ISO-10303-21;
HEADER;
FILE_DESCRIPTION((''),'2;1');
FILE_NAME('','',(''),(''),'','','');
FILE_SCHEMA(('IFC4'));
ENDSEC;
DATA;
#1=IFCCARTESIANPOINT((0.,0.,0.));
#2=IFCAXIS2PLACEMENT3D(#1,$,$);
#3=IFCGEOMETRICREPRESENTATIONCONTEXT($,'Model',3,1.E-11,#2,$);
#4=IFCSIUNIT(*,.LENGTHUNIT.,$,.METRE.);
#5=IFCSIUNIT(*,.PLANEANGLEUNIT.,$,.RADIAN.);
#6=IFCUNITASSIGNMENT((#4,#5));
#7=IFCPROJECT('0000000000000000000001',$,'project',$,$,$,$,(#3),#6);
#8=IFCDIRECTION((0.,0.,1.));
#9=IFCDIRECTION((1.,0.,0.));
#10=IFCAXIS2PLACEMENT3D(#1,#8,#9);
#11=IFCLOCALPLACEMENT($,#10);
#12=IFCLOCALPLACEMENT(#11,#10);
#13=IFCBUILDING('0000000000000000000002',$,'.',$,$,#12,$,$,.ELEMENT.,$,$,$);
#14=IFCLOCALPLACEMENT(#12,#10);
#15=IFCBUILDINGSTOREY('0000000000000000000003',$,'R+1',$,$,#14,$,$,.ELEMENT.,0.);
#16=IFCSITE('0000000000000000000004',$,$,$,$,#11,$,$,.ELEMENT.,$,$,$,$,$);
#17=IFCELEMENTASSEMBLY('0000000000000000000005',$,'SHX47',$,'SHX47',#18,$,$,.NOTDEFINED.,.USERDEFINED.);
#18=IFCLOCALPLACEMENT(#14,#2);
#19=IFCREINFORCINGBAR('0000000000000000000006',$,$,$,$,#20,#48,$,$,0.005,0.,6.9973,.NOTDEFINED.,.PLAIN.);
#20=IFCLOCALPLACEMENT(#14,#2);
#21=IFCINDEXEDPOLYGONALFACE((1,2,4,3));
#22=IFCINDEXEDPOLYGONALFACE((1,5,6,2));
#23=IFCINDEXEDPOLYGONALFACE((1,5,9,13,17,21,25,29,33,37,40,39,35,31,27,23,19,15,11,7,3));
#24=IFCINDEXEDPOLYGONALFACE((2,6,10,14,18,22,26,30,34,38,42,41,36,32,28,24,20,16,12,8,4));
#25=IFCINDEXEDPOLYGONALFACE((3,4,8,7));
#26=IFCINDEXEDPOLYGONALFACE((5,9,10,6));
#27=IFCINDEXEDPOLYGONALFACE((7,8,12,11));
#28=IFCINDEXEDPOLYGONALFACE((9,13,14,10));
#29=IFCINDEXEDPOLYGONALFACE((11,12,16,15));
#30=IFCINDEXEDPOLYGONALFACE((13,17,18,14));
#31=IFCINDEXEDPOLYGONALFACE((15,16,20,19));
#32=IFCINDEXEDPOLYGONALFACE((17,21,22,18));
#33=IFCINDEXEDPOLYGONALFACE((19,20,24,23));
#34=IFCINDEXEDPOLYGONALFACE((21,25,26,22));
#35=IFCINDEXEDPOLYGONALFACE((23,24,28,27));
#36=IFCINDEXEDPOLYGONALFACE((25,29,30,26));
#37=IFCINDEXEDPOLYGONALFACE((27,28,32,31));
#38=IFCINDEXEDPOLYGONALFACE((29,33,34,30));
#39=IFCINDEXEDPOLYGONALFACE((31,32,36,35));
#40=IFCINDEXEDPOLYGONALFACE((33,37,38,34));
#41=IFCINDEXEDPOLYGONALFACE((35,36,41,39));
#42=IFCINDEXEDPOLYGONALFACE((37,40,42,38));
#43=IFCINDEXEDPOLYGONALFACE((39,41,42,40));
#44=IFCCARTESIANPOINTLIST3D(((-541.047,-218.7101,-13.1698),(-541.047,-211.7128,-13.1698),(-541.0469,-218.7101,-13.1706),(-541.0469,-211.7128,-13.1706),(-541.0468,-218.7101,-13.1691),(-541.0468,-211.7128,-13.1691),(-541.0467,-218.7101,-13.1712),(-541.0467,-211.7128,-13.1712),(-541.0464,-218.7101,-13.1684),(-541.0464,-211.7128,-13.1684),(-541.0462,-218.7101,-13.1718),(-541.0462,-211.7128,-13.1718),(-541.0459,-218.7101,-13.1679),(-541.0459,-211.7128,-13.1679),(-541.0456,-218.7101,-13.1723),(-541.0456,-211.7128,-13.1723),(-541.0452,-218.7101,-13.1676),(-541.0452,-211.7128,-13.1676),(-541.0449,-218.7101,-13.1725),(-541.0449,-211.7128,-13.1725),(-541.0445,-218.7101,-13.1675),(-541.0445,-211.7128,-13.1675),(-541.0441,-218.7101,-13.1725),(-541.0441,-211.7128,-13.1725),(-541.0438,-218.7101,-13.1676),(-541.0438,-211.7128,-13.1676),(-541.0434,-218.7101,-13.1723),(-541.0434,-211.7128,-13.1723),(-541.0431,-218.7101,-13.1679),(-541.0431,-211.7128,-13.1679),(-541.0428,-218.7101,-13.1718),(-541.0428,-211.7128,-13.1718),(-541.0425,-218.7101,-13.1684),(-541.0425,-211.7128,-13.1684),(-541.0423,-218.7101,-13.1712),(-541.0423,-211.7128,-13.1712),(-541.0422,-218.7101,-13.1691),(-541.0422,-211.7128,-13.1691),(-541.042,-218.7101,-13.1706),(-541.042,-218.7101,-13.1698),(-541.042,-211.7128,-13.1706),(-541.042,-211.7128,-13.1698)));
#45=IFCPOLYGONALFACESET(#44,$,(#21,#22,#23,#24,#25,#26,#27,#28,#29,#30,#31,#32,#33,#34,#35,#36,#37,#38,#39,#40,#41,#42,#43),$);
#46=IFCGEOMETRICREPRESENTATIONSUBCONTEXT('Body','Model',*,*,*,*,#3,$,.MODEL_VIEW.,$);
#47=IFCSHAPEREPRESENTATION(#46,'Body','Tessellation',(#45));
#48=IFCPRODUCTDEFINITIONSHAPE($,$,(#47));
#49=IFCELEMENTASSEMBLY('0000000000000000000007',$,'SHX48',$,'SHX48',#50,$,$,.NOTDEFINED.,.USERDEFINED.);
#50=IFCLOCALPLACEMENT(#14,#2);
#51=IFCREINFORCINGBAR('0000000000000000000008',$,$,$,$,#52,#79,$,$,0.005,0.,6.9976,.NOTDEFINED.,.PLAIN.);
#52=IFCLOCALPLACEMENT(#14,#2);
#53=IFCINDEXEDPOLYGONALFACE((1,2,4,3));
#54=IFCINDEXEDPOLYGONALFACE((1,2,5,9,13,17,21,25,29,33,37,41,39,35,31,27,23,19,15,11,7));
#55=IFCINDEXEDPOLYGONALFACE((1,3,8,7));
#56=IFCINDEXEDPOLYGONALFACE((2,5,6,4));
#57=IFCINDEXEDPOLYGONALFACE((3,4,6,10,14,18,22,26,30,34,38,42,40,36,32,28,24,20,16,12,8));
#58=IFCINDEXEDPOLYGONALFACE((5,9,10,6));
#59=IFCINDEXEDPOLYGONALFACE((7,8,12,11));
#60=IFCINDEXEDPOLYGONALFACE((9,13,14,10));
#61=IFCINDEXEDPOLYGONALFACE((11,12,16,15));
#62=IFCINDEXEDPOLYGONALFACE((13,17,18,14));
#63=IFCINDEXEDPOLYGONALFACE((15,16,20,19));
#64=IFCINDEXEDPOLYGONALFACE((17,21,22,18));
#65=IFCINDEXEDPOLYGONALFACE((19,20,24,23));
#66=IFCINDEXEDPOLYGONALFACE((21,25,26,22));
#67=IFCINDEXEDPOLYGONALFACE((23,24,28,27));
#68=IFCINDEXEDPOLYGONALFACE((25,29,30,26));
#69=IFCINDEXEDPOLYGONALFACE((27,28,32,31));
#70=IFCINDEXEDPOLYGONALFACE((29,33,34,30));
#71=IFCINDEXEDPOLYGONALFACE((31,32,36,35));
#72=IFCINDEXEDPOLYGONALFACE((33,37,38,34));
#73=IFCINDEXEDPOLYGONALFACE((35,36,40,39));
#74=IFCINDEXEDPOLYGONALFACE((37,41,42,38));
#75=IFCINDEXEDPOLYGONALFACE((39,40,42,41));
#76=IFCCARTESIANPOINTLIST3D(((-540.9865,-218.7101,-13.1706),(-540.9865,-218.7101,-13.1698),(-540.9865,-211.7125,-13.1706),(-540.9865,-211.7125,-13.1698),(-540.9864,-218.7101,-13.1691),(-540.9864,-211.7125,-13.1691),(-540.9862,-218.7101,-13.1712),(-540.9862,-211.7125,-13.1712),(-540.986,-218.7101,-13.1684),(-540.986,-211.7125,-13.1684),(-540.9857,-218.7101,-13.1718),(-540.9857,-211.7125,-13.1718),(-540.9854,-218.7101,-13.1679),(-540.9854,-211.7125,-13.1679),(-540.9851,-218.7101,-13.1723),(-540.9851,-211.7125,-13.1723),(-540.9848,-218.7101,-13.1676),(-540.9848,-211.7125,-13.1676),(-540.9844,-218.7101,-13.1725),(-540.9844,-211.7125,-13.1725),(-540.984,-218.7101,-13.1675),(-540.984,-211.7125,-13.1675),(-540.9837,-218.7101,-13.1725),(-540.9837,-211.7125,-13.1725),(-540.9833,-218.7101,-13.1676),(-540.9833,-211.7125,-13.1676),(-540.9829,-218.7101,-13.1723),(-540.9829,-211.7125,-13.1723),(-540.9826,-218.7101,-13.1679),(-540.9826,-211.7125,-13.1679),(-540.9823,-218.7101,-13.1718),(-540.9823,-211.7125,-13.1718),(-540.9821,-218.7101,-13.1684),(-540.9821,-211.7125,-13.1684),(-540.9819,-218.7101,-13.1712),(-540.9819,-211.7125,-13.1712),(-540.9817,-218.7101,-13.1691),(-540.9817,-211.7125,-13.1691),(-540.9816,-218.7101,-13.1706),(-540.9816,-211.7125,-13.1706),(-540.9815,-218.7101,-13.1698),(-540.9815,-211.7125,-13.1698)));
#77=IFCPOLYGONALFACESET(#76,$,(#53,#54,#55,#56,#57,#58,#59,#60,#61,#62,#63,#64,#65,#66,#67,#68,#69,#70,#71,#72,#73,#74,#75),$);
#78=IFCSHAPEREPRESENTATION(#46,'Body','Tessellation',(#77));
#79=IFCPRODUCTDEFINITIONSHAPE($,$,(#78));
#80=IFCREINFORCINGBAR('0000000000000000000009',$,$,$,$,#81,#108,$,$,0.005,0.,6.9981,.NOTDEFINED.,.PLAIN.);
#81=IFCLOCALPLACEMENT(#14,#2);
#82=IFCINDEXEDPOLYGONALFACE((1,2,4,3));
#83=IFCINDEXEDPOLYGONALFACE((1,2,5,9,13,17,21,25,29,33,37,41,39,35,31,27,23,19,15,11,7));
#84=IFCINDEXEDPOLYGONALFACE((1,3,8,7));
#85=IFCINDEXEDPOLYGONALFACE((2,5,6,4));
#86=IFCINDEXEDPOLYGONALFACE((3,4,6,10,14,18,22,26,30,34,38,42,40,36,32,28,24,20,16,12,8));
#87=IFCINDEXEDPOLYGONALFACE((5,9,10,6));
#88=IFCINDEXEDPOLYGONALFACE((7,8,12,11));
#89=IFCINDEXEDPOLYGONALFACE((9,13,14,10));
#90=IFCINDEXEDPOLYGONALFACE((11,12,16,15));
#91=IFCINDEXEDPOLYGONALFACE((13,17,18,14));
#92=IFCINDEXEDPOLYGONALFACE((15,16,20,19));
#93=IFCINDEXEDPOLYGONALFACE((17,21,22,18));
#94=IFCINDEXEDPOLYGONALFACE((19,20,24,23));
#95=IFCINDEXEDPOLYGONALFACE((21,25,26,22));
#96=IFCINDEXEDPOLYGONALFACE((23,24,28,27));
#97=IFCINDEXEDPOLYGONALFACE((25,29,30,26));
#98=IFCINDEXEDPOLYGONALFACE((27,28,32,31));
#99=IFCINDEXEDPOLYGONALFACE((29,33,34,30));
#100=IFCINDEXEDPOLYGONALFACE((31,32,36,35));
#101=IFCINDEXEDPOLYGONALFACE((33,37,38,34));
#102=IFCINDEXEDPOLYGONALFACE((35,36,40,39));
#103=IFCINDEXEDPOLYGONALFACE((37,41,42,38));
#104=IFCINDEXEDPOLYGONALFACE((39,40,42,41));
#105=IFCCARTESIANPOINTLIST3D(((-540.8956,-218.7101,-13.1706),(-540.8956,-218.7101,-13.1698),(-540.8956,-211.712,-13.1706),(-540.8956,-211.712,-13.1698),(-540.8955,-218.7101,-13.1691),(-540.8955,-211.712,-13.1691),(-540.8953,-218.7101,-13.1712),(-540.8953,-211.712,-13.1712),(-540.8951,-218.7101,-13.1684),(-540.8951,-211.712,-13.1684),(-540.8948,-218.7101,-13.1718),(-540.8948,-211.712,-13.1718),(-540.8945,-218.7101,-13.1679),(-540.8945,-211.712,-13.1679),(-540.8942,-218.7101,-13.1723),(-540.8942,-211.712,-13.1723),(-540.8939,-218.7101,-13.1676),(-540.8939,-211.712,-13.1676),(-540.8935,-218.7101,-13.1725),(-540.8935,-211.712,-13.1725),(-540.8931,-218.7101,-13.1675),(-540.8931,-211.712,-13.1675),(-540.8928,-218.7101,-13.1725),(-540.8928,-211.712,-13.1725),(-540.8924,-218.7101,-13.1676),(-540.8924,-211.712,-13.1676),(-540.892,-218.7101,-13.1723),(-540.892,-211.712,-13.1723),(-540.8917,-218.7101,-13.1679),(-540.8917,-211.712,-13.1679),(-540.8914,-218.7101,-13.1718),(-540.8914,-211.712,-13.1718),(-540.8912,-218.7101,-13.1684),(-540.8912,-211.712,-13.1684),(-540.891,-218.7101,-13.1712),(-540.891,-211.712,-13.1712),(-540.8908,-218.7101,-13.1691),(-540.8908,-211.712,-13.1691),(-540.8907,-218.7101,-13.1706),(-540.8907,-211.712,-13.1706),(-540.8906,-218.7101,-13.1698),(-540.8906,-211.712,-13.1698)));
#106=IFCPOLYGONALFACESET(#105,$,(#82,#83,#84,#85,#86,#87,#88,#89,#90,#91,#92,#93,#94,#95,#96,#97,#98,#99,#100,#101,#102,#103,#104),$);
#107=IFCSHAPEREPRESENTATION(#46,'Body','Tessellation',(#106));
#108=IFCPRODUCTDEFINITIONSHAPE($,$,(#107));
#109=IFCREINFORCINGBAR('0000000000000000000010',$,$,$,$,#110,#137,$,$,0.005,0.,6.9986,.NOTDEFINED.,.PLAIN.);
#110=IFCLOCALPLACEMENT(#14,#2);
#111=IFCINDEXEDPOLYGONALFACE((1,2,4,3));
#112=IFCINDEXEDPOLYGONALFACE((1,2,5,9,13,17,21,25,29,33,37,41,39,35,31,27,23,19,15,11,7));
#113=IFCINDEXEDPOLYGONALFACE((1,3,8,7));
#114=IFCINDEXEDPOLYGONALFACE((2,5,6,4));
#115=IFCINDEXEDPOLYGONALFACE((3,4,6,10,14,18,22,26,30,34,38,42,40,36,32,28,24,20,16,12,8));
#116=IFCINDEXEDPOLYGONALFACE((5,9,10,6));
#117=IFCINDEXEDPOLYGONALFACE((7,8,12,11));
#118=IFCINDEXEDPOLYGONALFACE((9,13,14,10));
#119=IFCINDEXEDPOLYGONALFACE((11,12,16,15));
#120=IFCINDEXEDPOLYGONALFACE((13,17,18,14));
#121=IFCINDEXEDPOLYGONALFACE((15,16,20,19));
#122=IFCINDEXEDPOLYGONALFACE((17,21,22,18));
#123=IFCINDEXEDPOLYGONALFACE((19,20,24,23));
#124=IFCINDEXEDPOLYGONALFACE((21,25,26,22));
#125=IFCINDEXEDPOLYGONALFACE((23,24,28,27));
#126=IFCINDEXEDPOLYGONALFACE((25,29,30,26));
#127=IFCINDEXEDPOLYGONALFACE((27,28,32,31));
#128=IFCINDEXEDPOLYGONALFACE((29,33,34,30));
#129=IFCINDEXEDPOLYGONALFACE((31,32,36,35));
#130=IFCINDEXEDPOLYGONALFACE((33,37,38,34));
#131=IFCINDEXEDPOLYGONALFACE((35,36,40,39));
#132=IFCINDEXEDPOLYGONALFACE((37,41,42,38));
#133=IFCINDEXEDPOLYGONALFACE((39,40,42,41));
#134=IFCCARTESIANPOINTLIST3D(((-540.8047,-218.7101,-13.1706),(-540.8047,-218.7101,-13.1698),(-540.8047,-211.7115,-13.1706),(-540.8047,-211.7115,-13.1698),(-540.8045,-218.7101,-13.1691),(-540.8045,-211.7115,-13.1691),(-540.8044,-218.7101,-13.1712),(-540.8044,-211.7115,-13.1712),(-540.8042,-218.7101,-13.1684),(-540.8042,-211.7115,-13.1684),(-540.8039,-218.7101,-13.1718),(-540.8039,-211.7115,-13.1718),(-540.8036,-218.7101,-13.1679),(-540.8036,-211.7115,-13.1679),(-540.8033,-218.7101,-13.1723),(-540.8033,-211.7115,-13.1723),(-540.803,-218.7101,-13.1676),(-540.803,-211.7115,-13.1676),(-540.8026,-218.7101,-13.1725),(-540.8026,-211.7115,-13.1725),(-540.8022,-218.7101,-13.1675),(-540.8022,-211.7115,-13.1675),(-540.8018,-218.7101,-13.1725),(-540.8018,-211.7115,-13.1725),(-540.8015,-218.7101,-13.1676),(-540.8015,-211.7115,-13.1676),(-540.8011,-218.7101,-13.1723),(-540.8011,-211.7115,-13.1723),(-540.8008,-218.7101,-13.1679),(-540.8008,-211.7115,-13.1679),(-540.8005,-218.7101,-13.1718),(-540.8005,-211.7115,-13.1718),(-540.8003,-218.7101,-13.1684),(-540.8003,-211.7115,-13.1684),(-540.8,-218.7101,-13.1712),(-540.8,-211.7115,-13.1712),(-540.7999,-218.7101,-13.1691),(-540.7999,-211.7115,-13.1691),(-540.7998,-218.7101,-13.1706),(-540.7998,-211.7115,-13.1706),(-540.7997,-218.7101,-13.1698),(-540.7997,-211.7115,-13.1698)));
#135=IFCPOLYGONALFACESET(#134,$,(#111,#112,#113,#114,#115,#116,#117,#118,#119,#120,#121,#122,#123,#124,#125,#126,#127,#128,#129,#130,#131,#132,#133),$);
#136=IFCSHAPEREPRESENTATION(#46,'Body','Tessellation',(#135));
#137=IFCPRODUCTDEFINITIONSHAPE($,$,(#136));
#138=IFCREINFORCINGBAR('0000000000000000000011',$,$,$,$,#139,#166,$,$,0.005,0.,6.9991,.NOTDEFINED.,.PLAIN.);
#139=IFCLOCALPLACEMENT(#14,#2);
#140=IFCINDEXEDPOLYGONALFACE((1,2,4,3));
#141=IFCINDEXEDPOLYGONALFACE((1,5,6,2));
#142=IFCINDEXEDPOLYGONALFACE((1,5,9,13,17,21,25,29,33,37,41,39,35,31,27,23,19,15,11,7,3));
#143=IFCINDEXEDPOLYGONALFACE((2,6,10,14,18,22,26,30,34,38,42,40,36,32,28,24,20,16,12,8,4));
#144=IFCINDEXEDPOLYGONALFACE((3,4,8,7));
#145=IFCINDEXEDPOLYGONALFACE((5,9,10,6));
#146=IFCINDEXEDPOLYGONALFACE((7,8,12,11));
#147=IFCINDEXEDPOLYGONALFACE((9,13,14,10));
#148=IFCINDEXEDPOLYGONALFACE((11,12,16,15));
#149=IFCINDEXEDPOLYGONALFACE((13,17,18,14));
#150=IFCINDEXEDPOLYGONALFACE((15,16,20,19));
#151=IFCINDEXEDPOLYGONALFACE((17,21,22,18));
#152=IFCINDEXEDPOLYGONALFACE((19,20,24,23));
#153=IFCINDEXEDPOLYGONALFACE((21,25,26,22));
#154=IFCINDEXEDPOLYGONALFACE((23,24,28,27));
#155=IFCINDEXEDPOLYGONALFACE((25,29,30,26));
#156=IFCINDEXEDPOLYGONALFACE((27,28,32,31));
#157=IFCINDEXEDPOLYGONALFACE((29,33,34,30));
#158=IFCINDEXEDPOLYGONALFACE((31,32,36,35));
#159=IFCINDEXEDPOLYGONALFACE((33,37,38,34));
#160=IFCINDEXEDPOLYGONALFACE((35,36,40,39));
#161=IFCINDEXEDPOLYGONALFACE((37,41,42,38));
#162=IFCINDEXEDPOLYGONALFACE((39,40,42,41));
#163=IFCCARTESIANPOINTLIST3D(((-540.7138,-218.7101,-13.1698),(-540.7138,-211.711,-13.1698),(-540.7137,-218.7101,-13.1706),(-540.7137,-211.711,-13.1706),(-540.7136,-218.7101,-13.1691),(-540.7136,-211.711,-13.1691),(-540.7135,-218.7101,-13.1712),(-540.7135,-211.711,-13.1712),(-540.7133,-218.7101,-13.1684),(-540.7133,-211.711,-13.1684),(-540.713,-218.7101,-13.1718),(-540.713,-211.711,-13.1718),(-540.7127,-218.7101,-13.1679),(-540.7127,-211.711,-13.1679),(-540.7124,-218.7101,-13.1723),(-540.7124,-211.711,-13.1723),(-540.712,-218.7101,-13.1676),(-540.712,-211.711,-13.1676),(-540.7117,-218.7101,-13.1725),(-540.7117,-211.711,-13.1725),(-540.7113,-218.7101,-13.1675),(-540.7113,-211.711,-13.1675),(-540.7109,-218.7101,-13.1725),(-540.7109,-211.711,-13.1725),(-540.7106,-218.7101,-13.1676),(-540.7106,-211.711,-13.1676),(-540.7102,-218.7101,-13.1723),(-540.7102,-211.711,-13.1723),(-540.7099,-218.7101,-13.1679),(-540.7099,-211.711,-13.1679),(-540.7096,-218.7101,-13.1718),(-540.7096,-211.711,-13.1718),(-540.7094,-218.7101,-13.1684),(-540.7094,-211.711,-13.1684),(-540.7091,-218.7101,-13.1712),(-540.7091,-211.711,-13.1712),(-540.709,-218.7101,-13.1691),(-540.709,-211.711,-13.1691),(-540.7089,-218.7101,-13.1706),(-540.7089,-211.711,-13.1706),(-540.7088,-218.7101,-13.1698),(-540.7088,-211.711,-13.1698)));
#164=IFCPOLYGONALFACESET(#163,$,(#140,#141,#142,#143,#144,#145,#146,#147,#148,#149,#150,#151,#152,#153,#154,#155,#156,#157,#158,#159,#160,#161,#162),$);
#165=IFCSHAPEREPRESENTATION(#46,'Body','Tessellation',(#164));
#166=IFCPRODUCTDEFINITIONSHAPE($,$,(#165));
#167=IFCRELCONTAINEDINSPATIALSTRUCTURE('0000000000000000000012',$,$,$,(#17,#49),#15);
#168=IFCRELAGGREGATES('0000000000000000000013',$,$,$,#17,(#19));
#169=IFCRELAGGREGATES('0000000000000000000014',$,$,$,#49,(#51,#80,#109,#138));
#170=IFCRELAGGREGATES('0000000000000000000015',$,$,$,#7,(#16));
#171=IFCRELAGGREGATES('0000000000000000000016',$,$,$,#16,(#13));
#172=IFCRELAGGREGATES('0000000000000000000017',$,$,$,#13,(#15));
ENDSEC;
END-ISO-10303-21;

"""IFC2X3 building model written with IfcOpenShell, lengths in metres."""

from ifc_helpers import new_model, entity, si_unit, origin, origin_with_axes, place, context, subcontext, project, spatial, shape, element, aggregate, save


model = new_model("IFC2X3")

# Units and contexts
model_context = context("Model", 3, precision=1e-11, world=origin())
body_context = subcontext(model_context, "Body", "Model", "MODEL_VIEW")
ifc_project = project(units=[si_unit("LENGTHUNIT", "METRE"), si_unit("PLANEANGLEUNIT", "RADIAN")], contexts=[model_context])

# Site, building, storey
site_placement = place(None, origin_with_axes())
site = spatial("IfcSite", under=ifc_project, at=site_placement, CompositionType="ELEMENT")
building_placement = place(site_placement, origin_with_axes())
building = spatial("IfcBuilding", under=site, at=building_placement, Name=".", CompositionType="ELEMENT")
storey_placement = place(building_placement, origin_with_axes())
storey = spatial("IfcBuildingStorey", under=building, at=storey_placement, Name="R+1", CompositionType="ELEMENT", Elevation=0.0)

# Element assembly, reinforcing bar
assembly_1_placement = place(storey_placement, origin_with_axes())
assembly_1 = element("IfcElementAssembly", 1, at=assembly_1_placement, inside=storey, Name="SHX47", ObjectType="SHX47", AssemblyPlace="NOTDEFINED", PredefinedType="USERDEFINED")
reinforcing_bar_1_placement = place(assembly_1_placement, origin_with_axes())
reinforcing_bar_1 = element("IfcReinforcingBar", 2, at=reinforcing_bar_1_placement, BarLength=6.9973, BarRole="NOTDEFINED", BarSurface="PLAIN", CrossSectionArea=0.0, NominalDiameter=0.005, shapes=[
    shape(body_context, "Body", "AdvancedSweptSolid", [entity("IfcSweptDiskSolid", entity("IfcPolyline", [entity("IfcCartesianPoint", [541.0445, 211.7128, 13.17]), entity("IfcCartesianPoint", [541.0445, 218.7101, 13.17])]), 0.0025, None, 0.0, 6.9973)]),
    shape(body_context, "Body", "AdvancedSweptSolid", [entity("IfcSweptDiskSolid", entity("IfcPolyline", [entity("IfcCartesianPoint", [541.0445, 211.7128, 13.17]), entity("IfcCartesianPoint", [541.0445, 218.7101, 13.17])]), 0.0025, None, 0.0, 6.9973)]),
])
aggregate(assembly_1, [reinforcing_bar_1])

# Element assembly, reinforcing bars
assembly_2_placement = place(storey_placement, origin_with_axes())
assembly_2 = element("IfcElementAssembly", 3, at=assembly_2_placement, inside=storey, Name="SHX48", ObjectType="SHX48", AssemblyPlace="NOTDEFINED", PredefinedType="USERDEFINED")
reinforcing_bar_2_placement = place(assembly_2_placement, origin_with_axes())
reinforcing_bar_2 = element("IfcReinforcingBar", 4, at=reinforcing_bar_2_placement, BarLength=6.9976, BarRole="NOTDEFINED", BarSurface="PLAIN", CrossSectionArea=0.0, NominalDiameter=0.005, shapes=[
    shape(body_context, "Body", "AdvancedSweptSolid", [entity("IfcSweptDiskSolid", entity("IfcPolyline", [entity("IfcCartesianPoint", [540.984, 211.7125, 13.17]), entity("IfcCartesianPoint", [540.984, 218.7101, 13.17])]), 0.0025, None, 0.0, 6.9976)]),
    shape(body_context, "Body", "AdvancedSweptSolid", [entity("IfcSweptDiskSolid", entity("IfcPolyline", [entity("IfcCartesianPoint", [540.984, 211.7125, 13.17]), entity("IfcCartesianPoint", [540.984, 218.7101, 13.17])]), 0.0025, None, 0.0, 6.9976)]),
])
reinforcing_bar_3_placement = place(assembly_2_placement, origin_with_axes())
reinforcing_bar_3 = element("IfcReinforcingBar", 5, at=reinforcing_bar_3_placement, BarLength=6.9981, BarRole="NOTDEFINED", BarSurface="PLAIN", CrossSectionArea=0.0, NominalDiameter=0.005, shapes=[
    shape(body_context, "Body", "AdvancedSweptSolid", [entity("IfcSweptDiskSolid", entity("IfcPolyline", [entity("IfcCartesianPoint", [540.8931, 211.712, 13.17]), entity("IfcCartesianPoint", [540.8931, 218.7101, 13.17])]), 0.0025, None, 0.0, 6.9981)]),
    shape(body_context, "Body", "AdvancedSweptSolid", [entity("IfcSweptDiskSolid", entity("IfcPolyline", [entity("IfcCartesianPoint", [540.8931, 211.712, 13.17]), entity("IfcCartesianPoint", [540.8931, 218.7101, 13.17])]), 0.0025, None, 0.0, 6.9981)]),
])
reinforcing_bar_4_placement = place(assembly_2_placement, origin_with_axes())
reinforcing_bar_4 = element("IfcReinforcingBar", 6, at=reinforcing_bar_4_placement, BarLength=6.9986, BarRole="NOTDEFINED", BarSurface="PLAIN", CrossSectionArea=0.0, NominalDiameter=0.005, shapes=[
    shape(body_context, "Body", "AdvancedSweptSolid", [entity("IfcSweptDiskSolid", entity("IfcPolyline", [entity("IfcCartesianPoint", [540.8022, 211.7115, 13.17]), entity("IfcCartesianPoint", [540.8022, 218.7101, 13.17])]), 0.0025, None, 0.0, 6.9986)]),
    shape(body_context, "Body", "AdvancedSweptSolid", [entity("IfcSweptDiskSolid", entity("IfcPolyline", [entity("IfcCartesianPoint", [540.8022, 211.7115, 13.17]), entity("IfcCartesianPoint", [540.8022, 218.7101, 13.17])]), 0.0025, None, 0.0, 6.9986)]),
])
reinforcing_bar_5_placement = place(assembly_2_placement, origin_with_axes())
reinforcing_bar_5 = element("IfcReinforcingBar", 7, at=reinforcing_bar_5_placement, BarLength=6.9991, BarRole="NOTDEFINED", BarSurface="PLAIN", CrossSectionArea=0.0, NominalDiameter=0.005, shapes=[
    shape(body_context, "Body", "AdvancedSweptSolid", [entity("IfcSweptDiskSolid", entity("IfcPolyline", [entity("IfcCartesianPoint", [540.7113, 211.711, 13.17]), entity("IfcCartesianPoint", [540.7113, 218.7101, 13.17])]), 0.0025, None, 0.0, 6.9991)]),
    shape(body_context, "Body", "AdvancedSweptSolid", [entity("IfcSweptDiskSolid", entity("IfcPolyline", [entity("IfcCartesianPoint", [540.7113, 211.711, 13.17]), entity("IfcCartesianPoint", [540.7113, 218.7101, 13.17])]), 0.0025, None, 0.0, 6.9991)]),
])
aggregate(assembly_2, [reinforcing_bar_2, reinforcing_bar_3, reinforcing_bar_4, reinforcing_bar_5])

save(model, "model.ifc")
